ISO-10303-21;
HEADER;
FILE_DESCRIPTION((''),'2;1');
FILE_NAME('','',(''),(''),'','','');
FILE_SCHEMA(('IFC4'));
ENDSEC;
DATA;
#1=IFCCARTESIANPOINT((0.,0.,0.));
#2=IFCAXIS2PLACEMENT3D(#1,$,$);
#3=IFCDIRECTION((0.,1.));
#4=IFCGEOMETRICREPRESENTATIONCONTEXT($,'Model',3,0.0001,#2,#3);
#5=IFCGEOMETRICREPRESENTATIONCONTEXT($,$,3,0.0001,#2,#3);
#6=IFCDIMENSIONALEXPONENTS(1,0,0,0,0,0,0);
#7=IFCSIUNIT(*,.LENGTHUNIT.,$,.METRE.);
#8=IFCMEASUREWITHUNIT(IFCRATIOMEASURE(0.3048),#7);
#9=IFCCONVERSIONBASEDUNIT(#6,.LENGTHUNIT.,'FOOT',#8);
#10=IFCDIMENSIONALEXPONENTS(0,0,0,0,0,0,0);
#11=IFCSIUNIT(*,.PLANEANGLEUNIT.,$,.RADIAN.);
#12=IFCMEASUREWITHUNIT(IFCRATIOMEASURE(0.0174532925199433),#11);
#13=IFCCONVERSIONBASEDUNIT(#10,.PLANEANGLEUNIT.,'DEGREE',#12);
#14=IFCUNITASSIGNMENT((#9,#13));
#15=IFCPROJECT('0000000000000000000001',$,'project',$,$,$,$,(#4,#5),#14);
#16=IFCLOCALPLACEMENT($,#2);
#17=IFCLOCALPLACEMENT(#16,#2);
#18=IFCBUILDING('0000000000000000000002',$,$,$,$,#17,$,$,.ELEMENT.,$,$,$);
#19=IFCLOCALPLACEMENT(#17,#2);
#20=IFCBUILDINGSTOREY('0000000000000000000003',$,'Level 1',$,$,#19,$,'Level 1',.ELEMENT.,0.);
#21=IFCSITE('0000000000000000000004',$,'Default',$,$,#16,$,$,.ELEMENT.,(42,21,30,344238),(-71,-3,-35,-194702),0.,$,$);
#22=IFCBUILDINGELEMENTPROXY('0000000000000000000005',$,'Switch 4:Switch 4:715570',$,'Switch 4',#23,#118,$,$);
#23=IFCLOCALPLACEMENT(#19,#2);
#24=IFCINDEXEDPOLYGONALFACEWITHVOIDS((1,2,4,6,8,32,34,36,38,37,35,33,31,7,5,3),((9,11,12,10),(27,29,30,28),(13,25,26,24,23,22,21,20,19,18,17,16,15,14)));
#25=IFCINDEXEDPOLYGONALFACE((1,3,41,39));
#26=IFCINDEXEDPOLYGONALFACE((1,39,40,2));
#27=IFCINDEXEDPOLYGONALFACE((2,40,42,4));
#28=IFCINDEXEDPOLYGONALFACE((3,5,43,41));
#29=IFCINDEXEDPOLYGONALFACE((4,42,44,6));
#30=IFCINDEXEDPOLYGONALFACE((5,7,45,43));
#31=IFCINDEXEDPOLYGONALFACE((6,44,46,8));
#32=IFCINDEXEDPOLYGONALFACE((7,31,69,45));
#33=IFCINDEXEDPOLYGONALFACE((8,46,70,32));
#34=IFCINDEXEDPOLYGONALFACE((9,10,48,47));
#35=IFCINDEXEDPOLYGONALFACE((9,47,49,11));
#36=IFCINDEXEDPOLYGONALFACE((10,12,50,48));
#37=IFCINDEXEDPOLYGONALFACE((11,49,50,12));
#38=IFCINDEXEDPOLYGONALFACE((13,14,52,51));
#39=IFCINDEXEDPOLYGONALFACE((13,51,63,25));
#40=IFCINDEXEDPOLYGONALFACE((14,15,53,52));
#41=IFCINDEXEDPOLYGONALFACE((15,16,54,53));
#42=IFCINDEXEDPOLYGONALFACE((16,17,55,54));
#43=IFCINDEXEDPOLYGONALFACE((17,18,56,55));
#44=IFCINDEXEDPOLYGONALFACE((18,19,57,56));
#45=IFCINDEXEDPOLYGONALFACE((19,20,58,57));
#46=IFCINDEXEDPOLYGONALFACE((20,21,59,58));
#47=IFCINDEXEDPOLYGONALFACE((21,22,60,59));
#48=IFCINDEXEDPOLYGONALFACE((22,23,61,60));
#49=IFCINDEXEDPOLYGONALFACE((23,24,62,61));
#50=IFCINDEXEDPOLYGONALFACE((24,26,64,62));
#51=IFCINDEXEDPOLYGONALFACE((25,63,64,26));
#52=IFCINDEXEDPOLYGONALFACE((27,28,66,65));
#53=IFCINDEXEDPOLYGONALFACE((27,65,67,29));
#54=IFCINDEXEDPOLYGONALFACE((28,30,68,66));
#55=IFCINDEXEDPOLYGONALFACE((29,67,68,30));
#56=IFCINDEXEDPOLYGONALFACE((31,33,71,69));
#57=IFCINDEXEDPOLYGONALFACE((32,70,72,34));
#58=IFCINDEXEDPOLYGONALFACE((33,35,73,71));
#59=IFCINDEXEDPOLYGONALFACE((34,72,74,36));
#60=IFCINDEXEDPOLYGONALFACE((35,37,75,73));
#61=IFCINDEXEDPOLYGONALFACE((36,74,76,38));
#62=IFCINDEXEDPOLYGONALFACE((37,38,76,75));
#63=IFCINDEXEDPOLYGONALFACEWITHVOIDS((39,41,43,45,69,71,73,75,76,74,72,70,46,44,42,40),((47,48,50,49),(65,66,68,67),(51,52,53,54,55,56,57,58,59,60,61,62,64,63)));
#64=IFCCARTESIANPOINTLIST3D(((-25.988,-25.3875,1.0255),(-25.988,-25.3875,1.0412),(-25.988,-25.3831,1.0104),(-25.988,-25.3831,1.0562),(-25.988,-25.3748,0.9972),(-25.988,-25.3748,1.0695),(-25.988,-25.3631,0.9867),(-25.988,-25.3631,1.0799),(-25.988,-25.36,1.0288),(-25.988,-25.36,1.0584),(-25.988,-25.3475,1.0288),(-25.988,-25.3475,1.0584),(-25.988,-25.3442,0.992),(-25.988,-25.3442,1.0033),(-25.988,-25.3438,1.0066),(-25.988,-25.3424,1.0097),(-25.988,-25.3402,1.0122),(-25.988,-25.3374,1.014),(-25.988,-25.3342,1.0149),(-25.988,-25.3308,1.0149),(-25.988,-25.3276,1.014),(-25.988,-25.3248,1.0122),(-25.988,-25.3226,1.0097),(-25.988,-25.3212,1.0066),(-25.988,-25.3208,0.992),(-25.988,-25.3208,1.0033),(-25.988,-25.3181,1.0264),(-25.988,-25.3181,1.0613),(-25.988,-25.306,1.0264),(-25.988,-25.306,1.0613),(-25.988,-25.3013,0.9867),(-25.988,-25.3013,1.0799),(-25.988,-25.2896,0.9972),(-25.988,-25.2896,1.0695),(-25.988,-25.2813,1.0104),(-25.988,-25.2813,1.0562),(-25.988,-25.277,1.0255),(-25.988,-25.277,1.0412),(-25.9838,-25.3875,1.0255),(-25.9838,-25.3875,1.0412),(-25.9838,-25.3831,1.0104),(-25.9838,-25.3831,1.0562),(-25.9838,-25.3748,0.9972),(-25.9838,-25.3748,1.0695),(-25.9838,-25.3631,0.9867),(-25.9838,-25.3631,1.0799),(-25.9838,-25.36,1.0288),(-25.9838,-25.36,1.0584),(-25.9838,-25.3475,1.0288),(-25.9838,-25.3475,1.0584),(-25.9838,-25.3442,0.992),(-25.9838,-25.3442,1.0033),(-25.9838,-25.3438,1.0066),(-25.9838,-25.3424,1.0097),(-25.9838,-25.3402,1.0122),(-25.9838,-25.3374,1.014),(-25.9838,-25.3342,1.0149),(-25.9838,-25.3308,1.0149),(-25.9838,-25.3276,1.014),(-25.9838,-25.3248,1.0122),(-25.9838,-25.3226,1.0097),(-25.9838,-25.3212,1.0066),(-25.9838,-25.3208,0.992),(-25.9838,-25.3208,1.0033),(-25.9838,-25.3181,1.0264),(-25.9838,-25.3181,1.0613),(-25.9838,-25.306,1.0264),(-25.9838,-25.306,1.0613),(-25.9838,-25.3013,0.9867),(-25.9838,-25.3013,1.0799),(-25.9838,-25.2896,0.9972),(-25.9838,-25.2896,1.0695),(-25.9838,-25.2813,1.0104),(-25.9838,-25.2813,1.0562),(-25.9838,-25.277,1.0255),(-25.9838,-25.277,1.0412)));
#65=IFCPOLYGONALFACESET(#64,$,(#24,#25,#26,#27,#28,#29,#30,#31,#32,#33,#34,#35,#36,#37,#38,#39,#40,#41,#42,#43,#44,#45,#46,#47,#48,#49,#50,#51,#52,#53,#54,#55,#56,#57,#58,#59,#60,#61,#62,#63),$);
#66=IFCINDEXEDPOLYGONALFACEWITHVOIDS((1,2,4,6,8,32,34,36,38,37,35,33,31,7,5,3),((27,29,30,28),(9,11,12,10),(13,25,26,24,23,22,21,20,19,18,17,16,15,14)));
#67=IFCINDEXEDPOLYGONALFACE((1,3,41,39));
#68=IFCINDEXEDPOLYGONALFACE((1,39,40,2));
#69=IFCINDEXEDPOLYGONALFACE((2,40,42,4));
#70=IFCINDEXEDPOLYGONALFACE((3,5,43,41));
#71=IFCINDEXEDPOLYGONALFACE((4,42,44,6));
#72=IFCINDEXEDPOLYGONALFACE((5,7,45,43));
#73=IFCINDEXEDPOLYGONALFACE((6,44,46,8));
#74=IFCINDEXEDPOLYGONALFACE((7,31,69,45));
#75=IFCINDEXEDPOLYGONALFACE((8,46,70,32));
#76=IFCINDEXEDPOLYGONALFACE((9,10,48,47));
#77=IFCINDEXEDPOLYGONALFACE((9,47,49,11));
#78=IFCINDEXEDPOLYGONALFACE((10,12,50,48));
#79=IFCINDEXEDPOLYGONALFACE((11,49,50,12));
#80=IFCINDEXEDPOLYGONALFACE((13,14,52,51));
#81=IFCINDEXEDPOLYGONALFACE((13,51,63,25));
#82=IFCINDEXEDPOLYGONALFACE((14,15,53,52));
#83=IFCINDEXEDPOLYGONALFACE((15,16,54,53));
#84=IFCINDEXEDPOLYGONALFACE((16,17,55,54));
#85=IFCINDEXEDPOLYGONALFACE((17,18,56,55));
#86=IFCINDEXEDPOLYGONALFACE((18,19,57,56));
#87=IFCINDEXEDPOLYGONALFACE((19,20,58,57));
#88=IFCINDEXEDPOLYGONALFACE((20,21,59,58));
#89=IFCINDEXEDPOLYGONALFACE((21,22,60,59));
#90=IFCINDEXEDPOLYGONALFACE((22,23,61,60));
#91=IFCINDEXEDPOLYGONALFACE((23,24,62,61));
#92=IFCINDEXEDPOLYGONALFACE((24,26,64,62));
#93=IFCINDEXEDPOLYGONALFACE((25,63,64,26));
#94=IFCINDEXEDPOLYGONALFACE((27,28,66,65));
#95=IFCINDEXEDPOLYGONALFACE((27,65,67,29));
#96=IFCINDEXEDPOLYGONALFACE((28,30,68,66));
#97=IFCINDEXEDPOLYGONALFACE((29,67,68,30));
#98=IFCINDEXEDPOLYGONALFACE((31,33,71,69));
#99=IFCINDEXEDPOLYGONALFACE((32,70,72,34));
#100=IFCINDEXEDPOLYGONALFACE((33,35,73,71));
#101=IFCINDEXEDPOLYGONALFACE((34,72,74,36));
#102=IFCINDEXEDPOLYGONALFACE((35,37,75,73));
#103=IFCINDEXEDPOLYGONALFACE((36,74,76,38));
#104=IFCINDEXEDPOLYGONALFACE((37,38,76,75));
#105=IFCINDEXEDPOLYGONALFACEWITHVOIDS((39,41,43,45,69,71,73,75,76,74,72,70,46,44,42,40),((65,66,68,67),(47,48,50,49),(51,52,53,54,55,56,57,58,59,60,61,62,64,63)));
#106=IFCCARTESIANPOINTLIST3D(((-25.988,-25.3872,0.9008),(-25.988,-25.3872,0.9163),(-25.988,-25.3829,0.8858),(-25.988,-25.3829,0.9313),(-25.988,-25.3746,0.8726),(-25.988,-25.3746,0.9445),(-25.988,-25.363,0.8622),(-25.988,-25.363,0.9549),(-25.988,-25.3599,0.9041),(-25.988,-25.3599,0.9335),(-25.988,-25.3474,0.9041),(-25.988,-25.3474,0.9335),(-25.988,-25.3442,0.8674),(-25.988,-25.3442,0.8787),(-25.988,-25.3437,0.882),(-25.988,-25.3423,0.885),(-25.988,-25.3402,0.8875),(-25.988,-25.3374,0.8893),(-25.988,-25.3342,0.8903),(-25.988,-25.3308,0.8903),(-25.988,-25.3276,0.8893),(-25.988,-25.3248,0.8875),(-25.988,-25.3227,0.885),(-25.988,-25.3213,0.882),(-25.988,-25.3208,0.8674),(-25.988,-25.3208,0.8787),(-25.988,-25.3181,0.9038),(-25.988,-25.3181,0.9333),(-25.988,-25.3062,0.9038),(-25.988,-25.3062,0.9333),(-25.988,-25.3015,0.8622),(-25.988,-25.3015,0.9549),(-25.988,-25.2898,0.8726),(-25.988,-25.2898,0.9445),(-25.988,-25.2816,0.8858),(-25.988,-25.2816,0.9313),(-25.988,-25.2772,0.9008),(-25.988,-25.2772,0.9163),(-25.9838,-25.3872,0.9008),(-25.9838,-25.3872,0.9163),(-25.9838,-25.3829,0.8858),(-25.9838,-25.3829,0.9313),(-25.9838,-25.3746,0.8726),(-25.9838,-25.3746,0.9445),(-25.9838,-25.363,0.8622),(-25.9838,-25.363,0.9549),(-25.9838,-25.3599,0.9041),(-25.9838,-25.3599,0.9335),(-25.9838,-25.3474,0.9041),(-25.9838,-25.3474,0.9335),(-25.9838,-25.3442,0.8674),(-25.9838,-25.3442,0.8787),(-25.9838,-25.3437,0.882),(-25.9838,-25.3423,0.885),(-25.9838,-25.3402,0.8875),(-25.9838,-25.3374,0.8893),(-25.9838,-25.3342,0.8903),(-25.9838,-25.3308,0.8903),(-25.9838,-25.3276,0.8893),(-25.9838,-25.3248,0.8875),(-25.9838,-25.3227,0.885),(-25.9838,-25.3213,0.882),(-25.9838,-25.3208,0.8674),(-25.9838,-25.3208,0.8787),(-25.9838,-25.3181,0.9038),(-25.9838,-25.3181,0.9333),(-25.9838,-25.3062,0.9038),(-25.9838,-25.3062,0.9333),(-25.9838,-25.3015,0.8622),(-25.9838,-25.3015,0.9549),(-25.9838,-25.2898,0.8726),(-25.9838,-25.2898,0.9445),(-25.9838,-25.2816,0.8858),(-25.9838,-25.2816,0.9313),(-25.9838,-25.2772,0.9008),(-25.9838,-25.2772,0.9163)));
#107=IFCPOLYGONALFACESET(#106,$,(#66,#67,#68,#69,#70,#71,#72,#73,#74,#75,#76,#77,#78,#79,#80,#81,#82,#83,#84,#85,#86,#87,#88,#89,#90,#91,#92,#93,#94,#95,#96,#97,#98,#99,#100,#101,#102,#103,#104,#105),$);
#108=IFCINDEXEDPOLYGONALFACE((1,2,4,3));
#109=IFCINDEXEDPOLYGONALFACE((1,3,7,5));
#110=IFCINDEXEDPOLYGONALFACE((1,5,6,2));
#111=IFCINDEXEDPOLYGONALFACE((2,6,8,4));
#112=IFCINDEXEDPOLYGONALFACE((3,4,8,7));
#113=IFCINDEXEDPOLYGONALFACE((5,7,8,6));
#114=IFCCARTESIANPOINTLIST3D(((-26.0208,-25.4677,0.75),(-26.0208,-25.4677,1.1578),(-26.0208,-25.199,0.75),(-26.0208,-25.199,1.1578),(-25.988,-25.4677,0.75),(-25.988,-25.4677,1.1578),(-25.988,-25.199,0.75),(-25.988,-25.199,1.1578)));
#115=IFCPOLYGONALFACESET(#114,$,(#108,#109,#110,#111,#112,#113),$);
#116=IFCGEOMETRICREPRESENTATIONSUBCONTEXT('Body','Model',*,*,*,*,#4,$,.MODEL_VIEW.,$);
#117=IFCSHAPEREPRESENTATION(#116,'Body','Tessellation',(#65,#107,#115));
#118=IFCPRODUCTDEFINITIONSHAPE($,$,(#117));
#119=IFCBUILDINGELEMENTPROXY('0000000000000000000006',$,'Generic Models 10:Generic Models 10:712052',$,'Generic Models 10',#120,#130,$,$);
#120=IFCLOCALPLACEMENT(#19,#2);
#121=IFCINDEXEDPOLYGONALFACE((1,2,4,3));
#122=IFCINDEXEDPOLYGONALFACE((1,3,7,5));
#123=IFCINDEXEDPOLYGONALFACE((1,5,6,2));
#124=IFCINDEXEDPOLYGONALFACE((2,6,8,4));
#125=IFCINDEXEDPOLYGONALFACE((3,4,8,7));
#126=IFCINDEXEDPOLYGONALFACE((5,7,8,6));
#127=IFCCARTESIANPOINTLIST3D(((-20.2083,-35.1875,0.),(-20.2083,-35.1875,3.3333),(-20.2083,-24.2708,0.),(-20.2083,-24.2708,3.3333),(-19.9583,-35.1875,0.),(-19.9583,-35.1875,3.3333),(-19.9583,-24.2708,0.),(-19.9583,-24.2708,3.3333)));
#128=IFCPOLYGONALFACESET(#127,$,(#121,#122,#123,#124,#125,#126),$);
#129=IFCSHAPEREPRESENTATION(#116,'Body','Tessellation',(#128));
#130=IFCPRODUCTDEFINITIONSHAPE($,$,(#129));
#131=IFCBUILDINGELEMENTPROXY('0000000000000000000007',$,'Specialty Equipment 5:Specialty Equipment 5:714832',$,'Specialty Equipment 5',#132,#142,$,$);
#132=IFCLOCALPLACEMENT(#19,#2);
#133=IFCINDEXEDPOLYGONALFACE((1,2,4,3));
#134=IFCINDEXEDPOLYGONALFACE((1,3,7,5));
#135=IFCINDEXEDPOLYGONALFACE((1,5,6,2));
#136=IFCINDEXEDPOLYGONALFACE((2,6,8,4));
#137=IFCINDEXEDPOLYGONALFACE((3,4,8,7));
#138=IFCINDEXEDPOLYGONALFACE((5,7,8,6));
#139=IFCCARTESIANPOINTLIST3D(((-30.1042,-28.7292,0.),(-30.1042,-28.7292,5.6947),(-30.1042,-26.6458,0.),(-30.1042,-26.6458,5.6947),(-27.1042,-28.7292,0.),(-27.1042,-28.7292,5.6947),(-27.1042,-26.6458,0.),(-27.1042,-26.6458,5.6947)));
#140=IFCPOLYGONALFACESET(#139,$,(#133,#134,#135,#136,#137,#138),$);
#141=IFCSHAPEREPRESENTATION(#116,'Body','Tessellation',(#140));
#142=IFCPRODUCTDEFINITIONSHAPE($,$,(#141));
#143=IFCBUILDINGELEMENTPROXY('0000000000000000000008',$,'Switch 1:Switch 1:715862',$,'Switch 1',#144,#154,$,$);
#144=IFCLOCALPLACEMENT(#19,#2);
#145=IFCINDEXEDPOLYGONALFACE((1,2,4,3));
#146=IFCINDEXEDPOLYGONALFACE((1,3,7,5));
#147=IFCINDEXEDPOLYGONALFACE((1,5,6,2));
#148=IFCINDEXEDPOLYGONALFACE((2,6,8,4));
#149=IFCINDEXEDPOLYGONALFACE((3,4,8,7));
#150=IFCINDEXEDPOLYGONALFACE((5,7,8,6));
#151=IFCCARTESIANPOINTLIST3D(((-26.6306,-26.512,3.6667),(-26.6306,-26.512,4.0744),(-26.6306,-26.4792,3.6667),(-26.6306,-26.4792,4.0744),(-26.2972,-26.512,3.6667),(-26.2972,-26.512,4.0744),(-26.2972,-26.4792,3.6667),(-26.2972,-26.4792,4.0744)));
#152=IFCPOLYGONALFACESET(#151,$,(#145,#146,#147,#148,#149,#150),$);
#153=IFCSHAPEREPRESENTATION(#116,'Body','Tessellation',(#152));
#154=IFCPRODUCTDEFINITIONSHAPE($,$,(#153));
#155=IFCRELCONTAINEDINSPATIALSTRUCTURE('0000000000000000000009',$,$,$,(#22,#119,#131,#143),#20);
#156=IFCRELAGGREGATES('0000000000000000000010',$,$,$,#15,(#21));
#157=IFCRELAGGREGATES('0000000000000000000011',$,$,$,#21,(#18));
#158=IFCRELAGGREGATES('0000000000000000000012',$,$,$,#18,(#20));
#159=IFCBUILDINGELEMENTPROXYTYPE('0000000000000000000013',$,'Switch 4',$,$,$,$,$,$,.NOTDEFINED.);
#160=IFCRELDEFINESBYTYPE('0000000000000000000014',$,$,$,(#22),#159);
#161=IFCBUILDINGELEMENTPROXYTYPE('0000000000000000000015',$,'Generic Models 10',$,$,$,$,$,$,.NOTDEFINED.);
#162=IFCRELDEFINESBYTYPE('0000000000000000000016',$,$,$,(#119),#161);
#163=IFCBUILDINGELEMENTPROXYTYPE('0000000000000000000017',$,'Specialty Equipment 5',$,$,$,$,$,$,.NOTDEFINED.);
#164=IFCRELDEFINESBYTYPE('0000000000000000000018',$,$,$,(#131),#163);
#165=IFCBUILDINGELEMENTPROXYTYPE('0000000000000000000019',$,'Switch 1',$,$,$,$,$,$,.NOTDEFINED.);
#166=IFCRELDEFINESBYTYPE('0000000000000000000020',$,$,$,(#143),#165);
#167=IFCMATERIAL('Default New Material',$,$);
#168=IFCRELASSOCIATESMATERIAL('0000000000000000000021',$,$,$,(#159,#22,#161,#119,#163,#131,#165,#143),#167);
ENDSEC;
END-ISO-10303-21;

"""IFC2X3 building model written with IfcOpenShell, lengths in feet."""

from ifc_helpers import new_model, entity, si_unit, converted_unit, direction, frame, frame_2d, origin, origin_2d_with_axis, place, context, subcontext, project, spatial, polyline, circle_curve, parameter, trimmed, segment, composite_curve, rectangle, outline, extrude, source, transform, mapped, material, type_object, type_shapes, element, save


model = new_model("IFC2X3")

# Units and contexts
model_context = context("Model", 3, precision=0.0001, world=origin(), true_north=direction((0.0, 1.0)))
context_of_model = context(None, 3, precision=0.0001, world=origin(), true_north=direction((0.0, 1.0)))
body_context = subcontext(model_context, "Body", "Model", "MODEL_VIEW")
ifc_project = project(units=[converted_unit("LENGTHUNIT", "FOOT", entity("IfcRatioMeasure", 0.3048), si_unit("LENGTHUNIT", "METRE"), dimensions=[1, 0, 0, 0, 0, 0, 0]), converted_unit("PLANEANGLEUNIT", "DEGREE", entity("IfcRatioMeasure", 0.0174532925199433), si_unit("PLANEANGLEUNIT", "RADIAN"), dimensions=[0, 0, 0, 0, 0, 0, 0])], contexts=[model_context, context_of_model])

# Site, building, storey
site_placement = place(None, origin())
site = spatial("IfcSite", under=ifc_project, at=site_placement, Name="Default", CompositionType="ELEMENT", RefLatitude=(42, 21, 30, 344238), RefLongitude=(-71, -3, -35, -194702), RefElevation=0.0)
building_placement = place(site_placement, origin())
building = spatial("IfcBuilding", under=site, at=building_placement, CompositionType="ELEMENT")
storey_placement = place(building_placement, origin())
storey = spatial("IfcBuildingStorey", under=building, at=storey_placement, Name="Level 1", LongName="Level 1", CompositionType="ELEMENT", Elevation=0.0)

# Shared definitions
ifc_material = material(Name="Default New Material")

# Building element proxies
building_element_proxy_type_1 = type_object("IfcBuildingElementProxyType", Name="Switch 4", PredefinedType="NOTDEFINED", material=ifc_material)
shared_shape_1 = source(origin(), body_context, "Body", "SweptSolid", [
    extrude(outline(composite_curve([segment(polyline([(-0.0309, -0.0466), (0.0309, -0.0466)]), True, "CONTINUOUS"), segment(trimmed(circle_curve(frame_2d((-0.0003, 0.0), x_axis=(-1.0, 0.0)), 0.0561), [parameter(123.794741)], [parameter(236.205259)], True, "PARAMETER"), True, "CONTINUOUS"), segment(polyline([(0.0309, 0.0466), (-0.0309, 0.0466)]), True, "CONTINUOUS"), segment(trimmed(circle_curve(frame_2d((0.0003, 0.0), x_axis=(1.0, 0.0)), 0.0561), [parameter(123.794741)], [parameter(236.205259)], True, "PARAMETER"), True, "CONTINUOUS")], self_intersect=False), holes=[polyline([(0.0142, 0.0279), (0.0262, 0.0279), (0.0262, -0.0069), (0.0142, -0.0069), (0.0142, 0.0279)]), polyline([(-0.0153, 0.025), (-0.0153, -0.0045), (-0.0278, -0.0045), (-0.0278, 0.025), (-0.0153, 0.025)]), composite_curve([segment(polyline([(-0.012, -0.0413), (-0.012, -0.03)]), True, "CONTINUOUS"), segment(trimmed(circle_curve(frame_2d((-0.0003, -0.03), x_axis=(-1.0, 0.0)), 0.0117), [parameter(180.0)], [parameter(0.0)], True, "PARAMETER"), False, "CONTINUOUS"), segment(polyline([(0.0115, -0.03), (0.0115, -0.0413)]), True, "CONTINUOUS"), segment(polyline([(0.0115, -0.0413), (-0.012, -0.0413)]), True, "CONTINUOUS")], self_intersect=False)]), frame((-0.0011, 0.0328, 0.2833), z_axis=(0.0, 1.0, 0.0), x_axis=(-1.0, 0.0, 0.0)), (0.0, 0.0, 1.0), 0.0042),
    extrude(outline(composite_curve([segment(polyline([(-0.0308, -0.0464), (0.0308, -0.0464)]), True, "CONTINUOUS"), segment(trimmed(circle_curve(frame_2d((-0.0003, 0.0), x_axis=(-1.0, 0.0)), 0.0558), [parameter(123.794741)], [parameter(236.205259)], True, "PARAMETER"), True, "CONTINUOUS"), segment(polyline([(0.0308, 0.0464), (-0.0308, 0.0464)]), True, "CONTINUOUS"), segment(trimmed(circle_curve(frame_2d((0.0003, 0.0), x_axis=(1.0, 0.0)), 0.0558), [parameter(123.794741)], [parameter(236.205259)], True, "PARAMETER"), True, "CONTINUOUS")], self_intersect=False), holes=[polyline([(0.0141, 0.0247), (0.026, 0.0247), (0.026, -0.0047), (0.0141, -0.0047), (0.0141, 0.0247)]), polyline([(-0.0152, 0.0249), (-0.0152, -0.0045), (-0.0277, -0.0045), (-0.0277, 0.0249), (-0.0152, 0.0249)]), composite_curve([segment(polyline([(-0.012, -0.0411), (-0.012, -0.0299)]), True, "CONTINUOUS"), segment(trimmed(circle_curve(frame_2d((-0.0003, -0.0299), x_axis=(-1.0, 0.0)), 0.0117), [parameter(180.0)], [parameter(0.0)], True, "PARAMETER"), False, "CONTINUOUS"), segment(polyline([(0.0114, -0.0299), (0.0114, -0.0411)]), True, "CONTINUOUS"), segment(polyline([(0.0114, -0.0411), (-0.012, -0.0411)]), True, "CONTINUOUS")], self_intersect=False)]), frame((-0.0011, 0.0328, 0.1586), z_axis=(0.0, 1.0, 0.0), x_axis=(-1.0, 0.0, 0.0)), (0.0, 0.0, 1.0), 0.0042),
    extrude(rectangle(XDim=0.0328, YDim=0.2687, at=origin_2d_with_axis()), frame((0.0, 0.0164, 0.0), z_axis=(0.0, 0.0, 1.0), x_axis=(0.0, -1.0, 0.0)), (0.0, 0.0, 1.0), 0.4078),
])
type_shapes(building_element_proxy_type_1, [shared_shape_1])
proxy_1_placement = place(storey_placement, frame((-26.0208, -25.3333, 0.75), z_axis=(0.0, 0.0, 1.0), x_axis=(0.0, -1.0, 0.0)))
element("IfcBuildingElementProxy", 1, at=proxy_1_placement, inside=storey, type_object=building_element_proxy_type_1, material=ifc_material, Name="Switch 4:Switch 4:715570", ObjectType="Switch 4", context=body_context, shape_type="MappedRepresentation", body=[
    mapped(shared_shape_1, transform((0.0, 0.0, 0.0), scale=1.0)),
])
building_element_proxy_type_2 = type_object("IfcBuildingElementProxyType", Name="Generic Models 10", PredefinedType="NOTDEFINED", material=ifc_material)
shared_shape_2 = source(origin(), body_context, "Body", "SweptSolid", [
    extrude(rectangle(XDim=10.9167, YDim=0.25, at=frame_2d((0.0, 0.0), x_axis=(1.0, 0.0))), frame((0.125, 5.4583, 0.0), z_axis=(0.0, 0.0, 1.0), x_axis=(0.0, -1.0, 0.0)), (0.0, 0.0, 1.0), 3.3333),
])
type_shapes(building_element_proxy_type_2, [shared_shape_2])
proxy_2_placement = place(storey_placement, frame((-20.2083, -35.1875, 0.0)))
element("IfcBuildingElementProxy", 2, at=proxy_2_placement, inside=storey, type_object=building_element_proxy_type_2, material=ifc_material, Name="Generic Models 10:Generic Models 10:712052", ObjectType="Generic Models 10", context=body_context, shape_type="MappedRepresentation", body=[
    mapped(shared_shape_2, transform((0.0, 0.0, 0.0), scale=1.0)),
])
building_element_proxy_type_3 = type_object("IfcBuildingElementProxyType", Name="Specialty Equipment 5", PredefinedType="NOTDEFINED", material=ifc_material)
shared_shape_3 = source(origin(), body_context, "Body", "SweptSolid", [
    extrude(rectangle(XDim=2.0833, YDim=3.0, at=frame_2d((0.0, 0.0), x_axis=(1.0, 0.0))), frame((1.5, 1.0417, 0.0), z_axis=(0.0, 0.0, 1.0), x_axis=(0.0, 1.0, 0.0)), (0.0, 0.0, 1.0), 5.6947),
])
type_shapes(building_element_proxy_type_3, [shared_shape_3])
proxy_3_placement = place(storey_placement, frame((-30.1042, -28.7292, 0.0)))
element("IfcBuildingElementProxy", 3, at=proxy_3_placement, inside=storey, type_object=building_element_proxy_type_3, material=ifc_material, Name="Specialty Equipment 5:Specialty Equipment 5:714832", ObjectType="Specialty Equipment 5", context=body_context, shape_type="MappedRepresentation", body=[
    mapped(shared_shape_3, transform((0.0, 0.0, 0.0), scale=1.0)),
])
building_element_proxy_type_4 = type_object("IfcBuildingElementProxyType", Name="Switch 1", PredefinedType="NOTDEFINED", material=ifc_material)
shared_shape_4 = source(origin(), body_context, "Body", "SweptSolid", [
    extrude(rectangle(XDim=0.0328, YDim=0.3333, at=origin_2d_with_axis()), frame((0.0358, -0.0164, 0.0), z_axis=(0.0, 0.0, 1.0), x_axis=(0.0, 1.0, 0.0)), (0.0, 0.0, 1.0), 0.4078),
])
type_shapes(building_element_proxy_type_4, [shared_shape_4])
proxy_4_placement = place(storey_placement, frame((-26.4997, -26.4792, 3.6667)))
element("IfcBuildingElementProxy", 4, at=proxy_4_placement, inside=storey, type_object=building_element_proxy_type_4, material=ifc_material, Name="Switch 1:Switch 1:715862", ObjectType="Switch 1", context=body_context, shape_type="MappedRepresentation", body=[
    mapped(shared_shape_4, transform((0.0, 0.0, 0.0), scale=1.0)),
])

save(model, "model.ifc")
